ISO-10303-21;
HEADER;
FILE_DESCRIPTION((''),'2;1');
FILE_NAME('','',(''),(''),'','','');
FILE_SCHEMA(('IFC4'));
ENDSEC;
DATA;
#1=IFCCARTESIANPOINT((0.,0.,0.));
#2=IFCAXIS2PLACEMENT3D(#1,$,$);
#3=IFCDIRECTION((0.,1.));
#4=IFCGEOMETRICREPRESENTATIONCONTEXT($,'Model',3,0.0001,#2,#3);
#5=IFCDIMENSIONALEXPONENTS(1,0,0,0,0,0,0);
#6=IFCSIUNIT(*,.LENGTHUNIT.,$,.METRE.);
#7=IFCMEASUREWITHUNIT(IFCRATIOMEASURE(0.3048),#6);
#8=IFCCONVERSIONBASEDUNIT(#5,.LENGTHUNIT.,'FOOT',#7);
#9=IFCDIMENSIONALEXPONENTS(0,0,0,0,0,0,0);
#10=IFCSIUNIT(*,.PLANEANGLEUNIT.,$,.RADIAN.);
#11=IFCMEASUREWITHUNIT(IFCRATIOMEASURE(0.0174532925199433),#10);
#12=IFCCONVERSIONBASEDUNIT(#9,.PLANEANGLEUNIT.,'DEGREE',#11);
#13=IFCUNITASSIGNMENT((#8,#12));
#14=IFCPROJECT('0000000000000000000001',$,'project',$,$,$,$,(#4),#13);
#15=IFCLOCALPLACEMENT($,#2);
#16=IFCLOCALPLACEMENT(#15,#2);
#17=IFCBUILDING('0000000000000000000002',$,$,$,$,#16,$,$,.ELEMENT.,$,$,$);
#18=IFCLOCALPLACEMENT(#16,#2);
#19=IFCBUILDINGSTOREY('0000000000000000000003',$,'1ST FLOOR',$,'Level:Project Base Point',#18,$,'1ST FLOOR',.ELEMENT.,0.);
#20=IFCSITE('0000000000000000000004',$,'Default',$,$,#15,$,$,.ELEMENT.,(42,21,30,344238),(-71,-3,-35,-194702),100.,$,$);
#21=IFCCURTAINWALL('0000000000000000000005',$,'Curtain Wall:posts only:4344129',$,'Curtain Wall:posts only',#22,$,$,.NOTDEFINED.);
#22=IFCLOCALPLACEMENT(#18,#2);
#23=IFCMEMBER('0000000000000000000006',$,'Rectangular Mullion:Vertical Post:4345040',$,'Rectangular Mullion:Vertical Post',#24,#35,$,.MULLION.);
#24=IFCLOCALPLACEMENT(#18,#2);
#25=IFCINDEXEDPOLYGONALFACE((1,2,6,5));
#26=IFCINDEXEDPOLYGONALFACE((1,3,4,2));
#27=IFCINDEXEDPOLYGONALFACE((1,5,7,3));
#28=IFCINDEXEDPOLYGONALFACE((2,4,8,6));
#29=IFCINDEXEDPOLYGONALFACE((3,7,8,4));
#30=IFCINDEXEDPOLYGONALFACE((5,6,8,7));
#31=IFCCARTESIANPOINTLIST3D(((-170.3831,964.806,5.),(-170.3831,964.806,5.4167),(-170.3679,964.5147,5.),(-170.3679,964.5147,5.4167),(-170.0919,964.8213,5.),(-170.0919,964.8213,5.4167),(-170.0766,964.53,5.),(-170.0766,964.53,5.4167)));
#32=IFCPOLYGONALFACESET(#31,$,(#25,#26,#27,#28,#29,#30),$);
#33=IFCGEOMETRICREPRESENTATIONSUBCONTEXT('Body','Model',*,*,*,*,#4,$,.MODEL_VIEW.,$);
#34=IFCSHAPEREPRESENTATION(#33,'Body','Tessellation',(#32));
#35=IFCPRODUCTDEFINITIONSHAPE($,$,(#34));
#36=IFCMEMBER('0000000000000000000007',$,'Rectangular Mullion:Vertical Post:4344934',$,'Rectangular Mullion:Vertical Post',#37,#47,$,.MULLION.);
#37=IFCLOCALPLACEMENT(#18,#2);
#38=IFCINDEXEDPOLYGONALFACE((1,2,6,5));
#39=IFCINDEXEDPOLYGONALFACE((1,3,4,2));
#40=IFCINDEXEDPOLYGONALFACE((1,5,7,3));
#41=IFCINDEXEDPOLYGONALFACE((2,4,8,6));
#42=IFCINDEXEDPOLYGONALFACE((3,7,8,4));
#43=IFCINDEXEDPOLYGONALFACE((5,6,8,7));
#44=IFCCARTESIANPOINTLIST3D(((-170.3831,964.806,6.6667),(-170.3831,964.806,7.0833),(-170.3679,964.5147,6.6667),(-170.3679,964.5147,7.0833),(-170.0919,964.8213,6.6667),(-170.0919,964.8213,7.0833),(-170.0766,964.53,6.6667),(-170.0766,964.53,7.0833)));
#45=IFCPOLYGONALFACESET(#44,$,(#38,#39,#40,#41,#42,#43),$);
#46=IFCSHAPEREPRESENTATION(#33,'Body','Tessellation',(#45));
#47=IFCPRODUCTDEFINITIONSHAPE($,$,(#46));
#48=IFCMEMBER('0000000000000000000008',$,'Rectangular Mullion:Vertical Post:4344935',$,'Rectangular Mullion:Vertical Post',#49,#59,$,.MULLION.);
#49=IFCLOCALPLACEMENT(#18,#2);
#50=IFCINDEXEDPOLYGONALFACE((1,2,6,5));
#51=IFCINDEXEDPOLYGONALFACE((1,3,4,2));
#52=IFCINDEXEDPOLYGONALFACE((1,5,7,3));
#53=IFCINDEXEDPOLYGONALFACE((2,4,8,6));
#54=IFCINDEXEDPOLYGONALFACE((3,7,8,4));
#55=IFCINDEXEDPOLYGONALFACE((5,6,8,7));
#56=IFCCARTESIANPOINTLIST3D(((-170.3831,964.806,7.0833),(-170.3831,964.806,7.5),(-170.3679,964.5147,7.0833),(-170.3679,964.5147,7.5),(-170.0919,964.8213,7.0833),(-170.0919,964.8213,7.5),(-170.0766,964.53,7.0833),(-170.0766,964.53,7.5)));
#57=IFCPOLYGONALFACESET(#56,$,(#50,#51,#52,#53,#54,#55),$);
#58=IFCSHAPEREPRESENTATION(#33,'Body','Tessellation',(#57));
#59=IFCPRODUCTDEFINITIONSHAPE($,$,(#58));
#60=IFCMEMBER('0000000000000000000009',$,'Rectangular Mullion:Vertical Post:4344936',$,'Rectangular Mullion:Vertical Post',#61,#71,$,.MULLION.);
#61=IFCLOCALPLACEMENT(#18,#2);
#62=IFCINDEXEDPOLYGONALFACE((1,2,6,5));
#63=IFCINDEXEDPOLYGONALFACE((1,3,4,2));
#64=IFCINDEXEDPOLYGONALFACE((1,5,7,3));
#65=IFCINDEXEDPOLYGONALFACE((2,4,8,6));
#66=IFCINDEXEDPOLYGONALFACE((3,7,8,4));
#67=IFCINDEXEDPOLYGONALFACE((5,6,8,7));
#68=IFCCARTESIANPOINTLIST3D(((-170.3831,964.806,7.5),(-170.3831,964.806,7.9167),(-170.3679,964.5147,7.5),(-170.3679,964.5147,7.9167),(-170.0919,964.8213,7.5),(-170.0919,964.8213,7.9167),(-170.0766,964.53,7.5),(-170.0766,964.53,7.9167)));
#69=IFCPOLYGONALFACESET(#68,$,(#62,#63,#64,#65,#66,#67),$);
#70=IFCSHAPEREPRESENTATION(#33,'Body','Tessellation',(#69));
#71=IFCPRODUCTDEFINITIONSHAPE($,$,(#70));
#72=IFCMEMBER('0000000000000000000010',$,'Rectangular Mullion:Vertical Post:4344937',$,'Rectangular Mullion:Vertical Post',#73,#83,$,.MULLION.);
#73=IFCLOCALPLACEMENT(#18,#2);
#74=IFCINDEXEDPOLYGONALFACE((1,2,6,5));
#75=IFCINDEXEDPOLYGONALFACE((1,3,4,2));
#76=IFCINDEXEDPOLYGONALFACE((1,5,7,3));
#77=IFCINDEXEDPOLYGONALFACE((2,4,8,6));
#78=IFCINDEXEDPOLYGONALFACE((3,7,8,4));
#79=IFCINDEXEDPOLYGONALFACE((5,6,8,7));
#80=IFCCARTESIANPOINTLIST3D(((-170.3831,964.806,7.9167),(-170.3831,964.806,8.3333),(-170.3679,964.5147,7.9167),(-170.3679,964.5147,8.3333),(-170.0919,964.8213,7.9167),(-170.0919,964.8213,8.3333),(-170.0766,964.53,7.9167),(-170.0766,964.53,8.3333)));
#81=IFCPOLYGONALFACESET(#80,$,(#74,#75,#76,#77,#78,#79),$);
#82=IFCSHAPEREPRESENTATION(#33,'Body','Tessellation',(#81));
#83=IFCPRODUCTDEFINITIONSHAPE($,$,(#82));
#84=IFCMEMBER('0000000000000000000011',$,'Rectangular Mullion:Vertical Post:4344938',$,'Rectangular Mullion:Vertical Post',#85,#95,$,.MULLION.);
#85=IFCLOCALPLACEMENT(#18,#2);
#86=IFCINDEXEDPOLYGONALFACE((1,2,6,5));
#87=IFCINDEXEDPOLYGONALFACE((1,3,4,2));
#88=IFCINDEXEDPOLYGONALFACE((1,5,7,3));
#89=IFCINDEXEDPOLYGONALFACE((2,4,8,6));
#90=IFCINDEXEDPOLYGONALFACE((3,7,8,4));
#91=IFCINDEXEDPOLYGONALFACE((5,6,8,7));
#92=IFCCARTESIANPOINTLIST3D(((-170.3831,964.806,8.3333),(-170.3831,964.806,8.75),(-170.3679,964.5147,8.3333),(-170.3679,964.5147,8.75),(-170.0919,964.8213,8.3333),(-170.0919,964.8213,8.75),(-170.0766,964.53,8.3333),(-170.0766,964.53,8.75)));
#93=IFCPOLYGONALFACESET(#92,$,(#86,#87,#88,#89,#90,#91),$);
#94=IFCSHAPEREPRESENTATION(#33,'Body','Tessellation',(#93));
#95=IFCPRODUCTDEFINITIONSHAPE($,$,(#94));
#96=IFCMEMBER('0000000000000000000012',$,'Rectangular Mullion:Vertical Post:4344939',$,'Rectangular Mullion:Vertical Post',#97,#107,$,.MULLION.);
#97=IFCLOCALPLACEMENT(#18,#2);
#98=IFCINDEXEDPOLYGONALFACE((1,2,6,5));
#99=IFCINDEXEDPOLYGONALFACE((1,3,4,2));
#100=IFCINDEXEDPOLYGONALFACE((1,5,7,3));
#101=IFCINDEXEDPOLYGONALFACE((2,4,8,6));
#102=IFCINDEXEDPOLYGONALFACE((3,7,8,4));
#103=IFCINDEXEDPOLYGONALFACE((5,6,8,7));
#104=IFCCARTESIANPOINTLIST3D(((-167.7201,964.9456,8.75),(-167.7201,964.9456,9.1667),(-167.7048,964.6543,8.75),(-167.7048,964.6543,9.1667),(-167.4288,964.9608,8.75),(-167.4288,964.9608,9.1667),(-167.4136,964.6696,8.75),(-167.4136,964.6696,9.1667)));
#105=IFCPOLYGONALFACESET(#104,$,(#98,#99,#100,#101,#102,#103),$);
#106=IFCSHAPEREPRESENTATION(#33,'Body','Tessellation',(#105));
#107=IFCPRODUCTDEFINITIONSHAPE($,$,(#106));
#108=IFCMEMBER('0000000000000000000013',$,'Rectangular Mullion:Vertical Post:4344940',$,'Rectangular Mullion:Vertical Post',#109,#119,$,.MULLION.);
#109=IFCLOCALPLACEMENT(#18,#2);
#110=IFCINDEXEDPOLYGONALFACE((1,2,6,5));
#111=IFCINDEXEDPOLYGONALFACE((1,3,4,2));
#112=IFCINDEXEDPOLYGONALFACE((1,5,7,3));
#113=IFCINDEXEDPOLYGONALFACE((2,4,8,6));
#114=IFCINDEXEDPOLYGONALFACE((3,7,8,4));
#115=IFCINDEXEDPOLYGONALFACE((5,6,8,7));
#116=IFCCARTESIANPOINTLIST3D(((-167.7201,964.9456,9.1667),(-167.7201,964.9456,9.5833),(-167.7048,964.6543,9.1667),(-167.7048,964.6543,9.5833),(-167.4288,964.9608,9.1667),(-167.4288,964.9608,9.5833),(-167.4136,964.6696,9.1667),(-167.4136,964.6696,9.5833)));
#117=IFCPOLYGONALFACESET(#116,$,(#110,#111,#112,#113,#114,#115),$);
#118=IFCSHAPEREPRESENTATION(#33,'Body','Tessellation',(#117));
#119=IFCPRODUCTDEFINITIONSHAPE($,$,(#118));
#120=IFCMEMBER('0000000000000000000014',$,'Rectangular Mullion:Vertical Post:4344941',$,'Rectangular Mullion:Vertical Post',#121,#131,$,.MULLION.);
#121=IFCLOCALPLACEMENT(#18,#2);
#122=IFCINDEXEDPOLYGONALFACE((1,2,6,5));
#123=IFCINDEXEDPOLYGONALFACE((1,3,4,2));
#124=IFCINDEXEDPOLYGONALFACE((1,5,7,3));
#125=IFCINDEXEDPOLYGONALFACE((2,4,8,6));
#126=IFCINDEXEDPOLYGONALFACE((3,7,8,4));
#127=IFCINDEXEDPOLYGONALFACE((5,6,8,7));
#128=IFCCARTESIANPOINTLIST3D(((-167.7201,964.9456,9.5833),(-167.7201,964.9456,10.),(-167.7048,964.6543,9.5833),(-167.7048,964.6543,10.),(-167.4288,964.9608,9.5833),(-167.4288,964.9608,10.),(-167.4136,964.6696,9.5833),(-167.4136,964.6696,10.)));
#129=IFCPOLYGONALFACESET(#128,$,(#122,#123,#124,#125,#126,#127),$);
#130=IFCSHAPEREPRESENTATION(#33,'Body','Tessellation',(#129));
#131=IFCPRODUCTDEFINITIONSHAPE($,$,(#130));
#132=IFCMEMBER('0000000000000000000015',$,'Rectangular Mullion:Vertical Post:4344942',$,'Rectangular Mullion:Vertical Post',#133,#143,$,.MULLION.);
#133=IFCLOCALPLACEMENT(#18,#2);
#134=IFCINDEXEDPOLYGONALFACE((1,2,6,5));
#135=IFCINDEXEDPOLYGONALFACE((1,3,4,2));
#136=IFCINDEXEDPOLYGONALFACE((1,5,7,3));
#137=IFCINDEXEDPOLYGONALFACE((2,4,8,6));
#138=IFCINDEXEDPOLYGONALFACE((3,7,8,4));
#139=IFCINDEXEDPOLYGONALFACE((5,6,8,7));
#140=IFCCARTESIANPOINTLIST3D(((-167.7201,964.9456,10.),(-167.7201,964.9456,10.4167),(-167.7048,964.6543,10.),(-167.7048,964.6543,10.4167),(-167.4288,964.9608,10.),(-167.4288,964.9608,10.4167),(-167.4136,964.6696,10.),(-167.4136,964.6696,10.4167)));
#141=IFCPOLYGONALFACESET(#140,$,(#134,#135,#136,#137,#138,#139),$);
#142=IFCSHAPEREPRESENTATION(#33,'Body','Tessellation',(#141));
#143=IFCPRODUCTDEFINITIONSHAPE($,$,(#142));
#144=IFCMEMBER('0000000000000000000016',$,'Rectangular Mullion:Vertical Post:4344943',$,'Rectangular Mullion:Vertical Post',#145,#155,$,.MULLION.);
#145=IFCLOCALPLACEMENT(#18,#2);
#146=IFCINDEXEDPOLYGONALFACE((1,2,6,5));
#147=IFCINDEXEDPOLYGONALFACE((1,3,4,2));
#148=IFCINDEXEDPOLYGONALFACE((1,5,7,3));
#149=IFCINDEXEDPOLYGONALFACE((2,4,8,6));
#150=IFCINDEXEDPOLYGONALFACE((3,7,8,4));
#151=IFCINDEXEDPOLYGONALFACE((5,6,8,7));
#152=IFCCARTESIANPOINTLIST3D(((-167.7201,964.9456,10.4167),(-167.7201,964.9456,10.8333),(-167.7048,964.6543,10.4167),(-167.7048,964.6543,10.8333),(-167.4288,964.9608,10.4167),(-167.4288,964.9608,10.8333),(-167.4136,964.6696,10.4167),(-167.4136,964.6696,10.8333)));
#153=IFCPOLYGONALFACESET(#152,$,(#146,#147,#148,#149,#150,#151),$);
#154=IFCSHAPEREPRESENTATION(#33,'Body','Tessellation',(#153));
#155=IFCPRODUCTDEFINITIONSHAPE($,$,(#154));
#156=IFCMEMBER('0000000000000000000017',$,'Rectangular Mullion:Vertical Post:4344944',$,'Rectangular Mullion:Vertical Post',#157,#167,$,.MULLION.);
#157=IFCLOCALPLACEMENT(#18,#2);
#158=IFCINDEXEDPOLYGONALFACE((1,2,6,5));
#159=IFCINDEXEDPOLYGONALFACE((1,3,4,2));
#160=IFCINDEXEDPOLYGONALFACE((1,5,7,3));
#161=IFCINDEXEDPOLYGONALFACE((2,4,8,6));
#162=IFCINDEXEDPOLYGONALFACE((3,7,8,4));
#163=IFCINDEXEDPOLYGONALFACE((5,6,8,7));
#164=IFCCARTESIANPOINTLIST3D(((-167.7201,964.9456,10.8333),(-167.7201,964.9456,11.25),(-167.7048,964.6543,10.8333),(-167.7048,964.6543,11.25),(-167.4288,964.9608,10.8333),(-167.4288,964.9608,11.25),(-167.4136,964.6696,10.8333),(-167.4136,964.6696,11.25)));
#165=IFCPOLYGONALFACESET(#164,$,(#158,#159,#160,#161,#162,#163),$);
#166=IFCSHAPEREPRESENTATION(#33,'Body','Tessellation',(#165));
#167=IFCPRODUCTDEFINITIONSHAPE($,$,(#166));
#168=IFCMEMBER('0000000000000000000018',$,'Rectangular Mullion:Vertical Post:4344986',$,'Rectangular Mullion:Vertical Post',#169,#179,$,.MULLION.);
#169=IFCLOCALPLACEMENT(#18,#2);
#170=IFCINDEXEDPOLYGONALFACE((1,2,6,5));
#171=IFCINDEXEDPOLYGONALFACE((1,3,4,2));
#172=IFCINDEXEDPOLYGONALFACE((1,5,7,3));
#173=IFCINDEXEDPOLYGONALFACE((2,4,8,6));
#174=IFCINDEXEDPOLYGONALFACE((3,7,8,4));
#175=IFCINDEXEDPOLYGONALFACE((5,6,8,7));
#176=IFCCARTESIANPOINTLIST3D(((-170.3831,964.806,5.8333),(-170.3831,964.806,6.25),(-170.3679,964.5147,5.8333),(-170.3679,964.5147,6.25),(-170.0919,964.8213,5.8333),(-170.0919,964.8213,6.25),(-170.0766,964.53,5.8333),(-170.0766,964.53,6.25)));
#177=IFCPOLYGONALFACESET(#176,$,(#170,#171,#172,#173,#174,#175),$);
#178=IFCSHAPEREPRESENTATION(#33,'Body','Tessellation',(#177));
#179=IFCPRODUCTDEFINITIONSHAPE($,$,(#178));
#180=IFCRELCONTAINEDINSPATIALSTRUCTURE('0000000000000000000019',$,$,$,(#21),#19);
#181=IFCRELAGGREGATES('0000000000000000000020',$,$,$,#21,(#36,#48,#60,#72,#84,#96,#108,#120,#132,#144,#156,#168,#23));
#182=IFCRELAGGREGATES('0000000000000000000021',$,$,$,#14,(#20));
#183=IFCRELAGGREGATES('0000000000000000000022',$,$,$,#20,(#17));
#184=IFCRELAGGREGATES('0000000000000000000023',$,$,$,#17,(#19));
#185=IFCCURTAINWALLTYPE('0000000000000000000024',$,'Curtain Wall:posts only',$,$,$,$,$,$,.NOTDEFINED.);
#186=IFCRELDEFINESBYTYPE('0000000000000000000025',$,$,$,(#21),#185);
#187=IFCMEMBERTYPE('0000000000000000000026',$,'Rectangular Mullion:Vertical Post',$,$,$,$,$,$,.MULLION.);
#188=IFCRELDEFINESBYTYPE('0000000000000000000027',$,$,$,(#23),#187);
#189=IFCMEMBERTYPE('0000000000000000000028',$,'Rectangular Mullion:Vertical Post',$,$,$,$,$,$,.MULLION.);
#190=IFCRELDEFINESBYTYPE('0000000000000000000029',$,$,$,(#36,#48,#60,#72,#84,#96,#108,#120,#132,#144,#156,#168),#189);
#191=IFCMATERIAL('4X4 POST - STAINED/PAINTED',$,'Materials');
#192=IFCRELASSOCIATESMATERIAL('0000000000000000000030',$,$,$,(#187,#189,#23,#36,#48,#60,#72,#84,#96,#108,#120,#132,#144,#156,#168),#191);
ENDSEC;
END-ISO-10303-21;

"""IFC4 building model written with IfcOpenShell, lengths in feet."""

from ifc_helpers import new_model, entity, si_unit, converted_unit, direction, frame, origin, origin_2d_with_axis, place, context, subcontext, project, spatial, rectangle, extrude, source, transform, mapped, material, material_profile, profile_set, profile_usage, type_object, type_shapes, element, aggregate, save


model = new_model("IFC4")

# Units and contexts
model_context = context("Model", 3, precision=0.0001, world=origin(), true_north=direction((0.0, 1.0)))
body_context = subcontext(model_context, "Body", "Model", "MODEL_VIEW")
ifc_project = project(units=[converted_unit("LENGTHUNIT", "FOOT", entity("IfcRatioMeasure", 0.3048), si_unit("LENGTHUNIT", "METRE"), dimensions=[1, 0, 0, 0, 0, 0, 0]), converted_unit("PLANEANGLEUNIT", "DEGREE", entity("IfcRatioMeasure", 0.0174532925199433), si_unit("PLANEANGLEUNIT", "RADIAN"), dimensions=[0, 0, 0, 0, 0, 0, 0])], contexts=[model_context])

# Site, building, storey
site_placement = place(None, origin())
site = spatial("IfcSite", under=ifc_project, at=site_placement, Name="Default", CompositionType="ELEMENT", RefLatitude=(42, 21, 30, 344238), RefLongitude=(-71, -3, -35, -194702), RefElevation=100.0)
building_placement = place(site_placement, origin())
building = spatial("IfcBuilding", under=site, at=building_placement, CompositionType="ELEMENT")
storey_placement = place(building_placement, origin())
storey = spatial("IfcBuildingStorey", under=building, at=storey_placement, Name="1ST FLOOR", ObjectType="Level:Project Base Point", LongName="1ST FLOOR", CompositionType="ELEMENT", Elevation=0.0)

# Curtain wall, members
curtain_wall_type_1 = type_object("IfcCurtainWallType", Name="Curtain Wall:posts only", PredefinedType="NOTDEFINED")
curtain_wall_1_placement = place(storey_placement, origin())
curtain_wall_1 = element("IfcCurtainWall", 1, at=curtain_wall_1_placement, inside=storey, type_object=curtain_wall_type_1, Name="Curtain Wall:posts only:4344129", ObjectType="Curtain Wall:posts only", PredefinedType="NOTDEFINED")
ifc_material_1 = material(Name="4X4 POST - STAINED/PAINTED", Category="Materials")
ifc_material_profile_1 = material_profile(ifc_material_1, rectangle(XDim=0.2917, YDim=0.2917, at=origin_2d_with_axis()), Name="Vertical Post")
ifc_profile_set_1 = profile_set([ifc_material_profile_1], Name="Vertical Post")
ifc_profile_usage_1 = profile_usage(ifc_profile_set_1)
member_type_1 = type_object("IfcMemberType", Name="Rectangular Mullion:Vertical Post", PredefinedType="MULLION", material=ifc_profile_set_1)
shared_shape_1 = source(origin(), body_context, "Body", "SweptSolid", [
    extrude(rectangle(XDim=0.2917, YDim=0.2917, at=origin_2d_with_axis()), frame((0.0, -0.2083, -0.4167), z_axis=(0.0, 0.0, 1.0), x_axis=(0.0, -1.0, 0.0)), (0.0, 0.0, 1.0), 0.4167),
])
type_shapes(member_type_1, [shared_shape_1])
member_1_placement = place(storey_placement, frame((-170.2408, 964.8761, 5.0), z_axis=(0.0, 0.0, -1.0), x_axis=(-0.99863, -0.052336, 0.0)))
member_1 = element("IfcMember", 2, at=member_1_placement, type_object=member_type_1, material=ifc_profile_usage_1, Name="Rectangular Mullion:Vertical Post:4345040", ObjectType="Rectangular Mullion:Vertical Post", PredefinedType="MULLION", context=body_context, shape_type="MappedRepresentation", body=[
    mapped(shared_shape_1, transform((0.0, 0.0, 0.0), scale=1.0)),
])
ifc_profile_usage_2 = profile_usage(ifc_profile_set_1)
member_type_2 = type_object("IfcMemberType", Name="Rectangular Mullion:Vertical Post", PredefinedType="MULLION", material=ifc_profile_set_1)
shared_shape_2 = source(origin(), body_context, "Body", "SweptSolid", [
    extrude(rectangle(XDim=0.2917, YDim=0.2917, at=origin_2d_with_axis()), frame((0.0, -0.2083, -0.4167), z_axis=(0.0, 0.0, 1.0), x_axis=(0.0, -1.0, 0.0)), (0.0, 0.0, 1.0), 0.4167),
])
type_shapes(member_type_2, [shared_shape_2])
member_2_placement = place(storey_placement, frame((-170.2408, 964.8761, 6.6667), z_axis=(0.0, 0.0, -1.0), x_axis=(-0.99863, -0.052336, 0.0)))
member_2 = element("IfcMember", 3, at=member_2_placement, type_object=member_type_2, material=ifc_profile_usage_2, Name="Rectangular Mullion:Vertical Post:4344934", ObjectType="Rectangular Mullion:Vertical Post", PredefinedType="MULLION", context=body_context, shape_type="MappedRepresentation", body=[
    mapped(shared_shape_2, transform((0.0, 0.0, 0.0), scale=1.0)),
])
ifc_profile_usage_3 = profile_usage(ifc_profile_set_1)
member_3_placement = place(storey_placement, frame((-170.2408, 964.8761, 7.0833), z_axis=(0.0, 0.0, -1.0), x_axis=(-0.99863, -0.052336, 0.0)))
member_3 = element("IfcMember", 4, at=member_3_placement, type_object=member_type_2, material=ifc_profile_usage_3, Name="Rectangular Mullion:Vertical Post:4344935", ObjectType="Rectangular Mullion:Vertical Post", PredefinedType="MULLION", context=body_context, shape_type="MappedRepresentation", body=[
    mapped(shared_shape_2, transform((0.0, 0.0, 0.0), scale=1.0)),
])
ifc_profile_usage_4 = profile_usage(ifc_profile_set_1)
member_4_placement = place(storey_placement, frame((-170.2408, 964.8761, 7.5), z_axis=(0.0, 0.0, -1.0), x_axis=(-0.99863, -0.052336, 0.0)))
member_4 = element("IfcMember", 5, at=member_4_placement, type_object=member_type_2, material=ifc_profile_usage_4, Name="Rectangular Mullion:Vertical Post:4344936", ObjectType="Rectangular Mullion:Vertical Post", PredefinedType="MULLION", context=body_context, shape_type="MappedRepresentation", body=[
    mapped(shared_shape_2, transform((0.0, 0.0, 0.0), scale=1.0)),
])
ifc_profile_usage_5 = profile_usage(ifc_profile_set_1)
member_5_placement = place(storey_placement, frame((-170.2408, 964.8761, 7.9167), z_axis=(0.0, 0.0, -1.0), x_axis=(-0.99863, -0.052336, 0.0)))
member_5 = element("IfcMember", 6, at=member_5_placement, type_object=member_type_2, material=ifc_profile_usage_5, Name="Rectangular Mullion:Vertical Post:4344937", ObjectType="Rectangular Mullion:Vertical Post", PredefinedType="MULLION", context=body_context, shape_type="MappedRepresentation", body=[
    mapped(shared_shape_2, transform((0.0, 0.0, 0.0), scale=1.0)),
])
ifc_profile_usage_6 = profile_usage(ifc_profile_set_1)
member_6_placement = place(storey_placement, frame((-170.2408, 964.8761, 8.3333), z_axis=(0.0, 0.0, -1.0), x_axis=(-0.99863, -0.052336, 0.0)))
member_6 = element("IfcMember", 7, at=member_6_placement, type_object=member_type_2, material=ifc_profile_usage_6, Name="Rectangular Mullion:Vertical Post:4344938", ObjectType="Rectangular Mullion:Vertical Post", PredefinedType="MULLION", context=body_context, shape_type="MappedRepresentation", body=[
    mapped(shared_shape_2, transform((0.0, 0.0, 0.0), scale=1.0)),
])
ifc_profile_usage_7 = profile_usage(ifc_profile_set_1)
member_7_placement = place(storey_placement, frame((-167.5777, 965.0156, 8.75), z_axis=(0.0, 0.0, -1.0), x_axis=(-0.99863, -0.052336, 0.0)))
member_7 = element("IfcMember", 8, at=member_7_placement, type_object=member_type_2, material=ifc_profile_usage_7, Name="Rectangular Mullion:Vertical Post:4344939", ObjectType="Rectangular Mullion:Vertical Post", PredefinedType="MULLION", context=body_context, shape_type="MappedRepresentation", body=[
    mapped(shared_shape_2, transform((0.0, 0.0, 0.0), scale=1.0)),
])
ifc_profile_usage_8 = profile_usage(ifc_profile_set_1)
member_8_placement = place(storey_placement, frame((-167.5777, 965.0156, 9.1667), z_axis=(0.0, 0.0, -1.0), x_axis=(-0.99863, -0.052336, 0.0)))
member_8 = element("IfcMember", 9, at=member_8_placement, type_object=member_type_2, material=ifc_profile_usage_8, Name="Rectangular Mullion:Vertical Post:4344940", ObjectType="Rectangular Mullion:Vertical Post", PredefinedType="MULLION", context=body_context, shape_type="MappedRepresentation", body=[
    mapped(shared_shape_2, transform((0.0, 0.0, 0.0), scale=1.0)),
])
ifc_profile_usage_9 = profile_usage(ifc_profile_set_1)
member_9_placement = place(storey_placement, frame((-167.5777, 965.0156, 9.5833), z_axis=(0.0, 0.0, -1.0), x_axis=(-0.99863, -0.052336, 0.0)))
member_9 = element("IfcMember", 10, at=member_9_placement, type_object=member_type_2, material=ifc_profile_usage_9, Name="Rectangular Mullion:Vertical Post:4344941", ObjectType="Rectangular Mullion:Vertical Post", PredefinedType="MULLION", context=body_context, shape_type="MappedRepresentation", body=[
    mapped(shared_shape_2, transform((0.0, 0.0, 0.0), scale=1.0)),
])
ifc_profile_usage_10 = profile_usage(ifc_profile_set_1)
member_10_placement = place(storey_placement, frame((-167.5777, 965.0156, 10.0), z_axis=(0.0, 0.0, -1.0), x_axis=(-0.99863, -0.052336, 0.0)))
member_10 = element("IfcMember", 11, at=member_10_placement, type_object=member_type_2, material=ifc_profile_usage_10, Name="Rectangular Mullion:Vertical Post:4344942", ObjectType="Rectangular Mullion:Vertical Post", PredefinedType="MULLION", context=body_context, shape_type="MappedRepresentation", body=[
    mapped(shared_shape_2, transform((0.0, 0.0, 0.0), scale=1.0)),
])
ifc_profile_usage_11 = profile_usage(ifc_profile_set_1)
member_11_placement = place(storey_placement, frame((-167.5777, 965.0156, 10.4167), z_axis=(0.0, 0.0, -1.0), x_axis=(-0.99863, -0.052336, 0.0)))
member_11 = element("IfcMember", 12, at=member_11_placement, type_object=member_type_2, material=ifc_profile_usage_11, Name="Rectangular Mullion:Vertical Post:4344943", ObjectType="Rectangular Mullion:Vertical Post", PredefinedType="MULLION", context=body_context, shape_type="MappedRepresentation", body=[
    mapped(shared_shape_2, transform((0.0, 0.0, 0.0), scale=1.0)),
])
ifc_profile_usage_12 = profile_usage(ifc_profile_set_1)
member_12_placement = place(storey_placement, frame((-167.5777, 965.0156, 10.8333), z_axis=(0.0, 0.0, -1.0), x_axis=(-0.99863, -0.052336, 0.0)))
member_12 = element("IfcMember", 13, at=member_12_placement, type_object=member_type_2, material=ifc_profile_usage_12, Name="Rectangular Mullion:Vertical Post:4344944", ObjectType="Rectangular Mullion:Vertical Post", PredefinedType="MULLION", context=body_context, shape_type="MappedRepresentation", body=[
    mapped(shared_shape_2, transform((0.0, 0.0, 0.0), scale=1.0)),
])
ifc_profile_usage_13 = profile_usage(ifc_profile_set_1)
member_13_placement = place(storey_placement, frame((-170.2408, 964.8761, 5.8333), z_axis=(0.0, 0.0, -1.0), x_axis=(-0.99863, -0.052336, 0.0)))
member_13 = element("IfcMember", 14, at=member_13_placement, type_object=member_type_2, material=ifc_profile_usage_13, Name="Rectangular Mullion:Vertical Post:4344986", ObjectType="Rectangular Mullion:Vertical Post", PredefinedType="MULLION", context=body_context, shape_type="MappedRepresentation", body=[
    mapped(shared_shape_2, transform((0.0, 0.0, 0.0), scale=1.0)),
])
aggregate(curtain_wall_1, [member_2, member_3, member_4, member_5, member_6, member_7, member_8, member_9, member_10, member_11, member_12, member_13, member_1])

save(model, "model.ifc")
